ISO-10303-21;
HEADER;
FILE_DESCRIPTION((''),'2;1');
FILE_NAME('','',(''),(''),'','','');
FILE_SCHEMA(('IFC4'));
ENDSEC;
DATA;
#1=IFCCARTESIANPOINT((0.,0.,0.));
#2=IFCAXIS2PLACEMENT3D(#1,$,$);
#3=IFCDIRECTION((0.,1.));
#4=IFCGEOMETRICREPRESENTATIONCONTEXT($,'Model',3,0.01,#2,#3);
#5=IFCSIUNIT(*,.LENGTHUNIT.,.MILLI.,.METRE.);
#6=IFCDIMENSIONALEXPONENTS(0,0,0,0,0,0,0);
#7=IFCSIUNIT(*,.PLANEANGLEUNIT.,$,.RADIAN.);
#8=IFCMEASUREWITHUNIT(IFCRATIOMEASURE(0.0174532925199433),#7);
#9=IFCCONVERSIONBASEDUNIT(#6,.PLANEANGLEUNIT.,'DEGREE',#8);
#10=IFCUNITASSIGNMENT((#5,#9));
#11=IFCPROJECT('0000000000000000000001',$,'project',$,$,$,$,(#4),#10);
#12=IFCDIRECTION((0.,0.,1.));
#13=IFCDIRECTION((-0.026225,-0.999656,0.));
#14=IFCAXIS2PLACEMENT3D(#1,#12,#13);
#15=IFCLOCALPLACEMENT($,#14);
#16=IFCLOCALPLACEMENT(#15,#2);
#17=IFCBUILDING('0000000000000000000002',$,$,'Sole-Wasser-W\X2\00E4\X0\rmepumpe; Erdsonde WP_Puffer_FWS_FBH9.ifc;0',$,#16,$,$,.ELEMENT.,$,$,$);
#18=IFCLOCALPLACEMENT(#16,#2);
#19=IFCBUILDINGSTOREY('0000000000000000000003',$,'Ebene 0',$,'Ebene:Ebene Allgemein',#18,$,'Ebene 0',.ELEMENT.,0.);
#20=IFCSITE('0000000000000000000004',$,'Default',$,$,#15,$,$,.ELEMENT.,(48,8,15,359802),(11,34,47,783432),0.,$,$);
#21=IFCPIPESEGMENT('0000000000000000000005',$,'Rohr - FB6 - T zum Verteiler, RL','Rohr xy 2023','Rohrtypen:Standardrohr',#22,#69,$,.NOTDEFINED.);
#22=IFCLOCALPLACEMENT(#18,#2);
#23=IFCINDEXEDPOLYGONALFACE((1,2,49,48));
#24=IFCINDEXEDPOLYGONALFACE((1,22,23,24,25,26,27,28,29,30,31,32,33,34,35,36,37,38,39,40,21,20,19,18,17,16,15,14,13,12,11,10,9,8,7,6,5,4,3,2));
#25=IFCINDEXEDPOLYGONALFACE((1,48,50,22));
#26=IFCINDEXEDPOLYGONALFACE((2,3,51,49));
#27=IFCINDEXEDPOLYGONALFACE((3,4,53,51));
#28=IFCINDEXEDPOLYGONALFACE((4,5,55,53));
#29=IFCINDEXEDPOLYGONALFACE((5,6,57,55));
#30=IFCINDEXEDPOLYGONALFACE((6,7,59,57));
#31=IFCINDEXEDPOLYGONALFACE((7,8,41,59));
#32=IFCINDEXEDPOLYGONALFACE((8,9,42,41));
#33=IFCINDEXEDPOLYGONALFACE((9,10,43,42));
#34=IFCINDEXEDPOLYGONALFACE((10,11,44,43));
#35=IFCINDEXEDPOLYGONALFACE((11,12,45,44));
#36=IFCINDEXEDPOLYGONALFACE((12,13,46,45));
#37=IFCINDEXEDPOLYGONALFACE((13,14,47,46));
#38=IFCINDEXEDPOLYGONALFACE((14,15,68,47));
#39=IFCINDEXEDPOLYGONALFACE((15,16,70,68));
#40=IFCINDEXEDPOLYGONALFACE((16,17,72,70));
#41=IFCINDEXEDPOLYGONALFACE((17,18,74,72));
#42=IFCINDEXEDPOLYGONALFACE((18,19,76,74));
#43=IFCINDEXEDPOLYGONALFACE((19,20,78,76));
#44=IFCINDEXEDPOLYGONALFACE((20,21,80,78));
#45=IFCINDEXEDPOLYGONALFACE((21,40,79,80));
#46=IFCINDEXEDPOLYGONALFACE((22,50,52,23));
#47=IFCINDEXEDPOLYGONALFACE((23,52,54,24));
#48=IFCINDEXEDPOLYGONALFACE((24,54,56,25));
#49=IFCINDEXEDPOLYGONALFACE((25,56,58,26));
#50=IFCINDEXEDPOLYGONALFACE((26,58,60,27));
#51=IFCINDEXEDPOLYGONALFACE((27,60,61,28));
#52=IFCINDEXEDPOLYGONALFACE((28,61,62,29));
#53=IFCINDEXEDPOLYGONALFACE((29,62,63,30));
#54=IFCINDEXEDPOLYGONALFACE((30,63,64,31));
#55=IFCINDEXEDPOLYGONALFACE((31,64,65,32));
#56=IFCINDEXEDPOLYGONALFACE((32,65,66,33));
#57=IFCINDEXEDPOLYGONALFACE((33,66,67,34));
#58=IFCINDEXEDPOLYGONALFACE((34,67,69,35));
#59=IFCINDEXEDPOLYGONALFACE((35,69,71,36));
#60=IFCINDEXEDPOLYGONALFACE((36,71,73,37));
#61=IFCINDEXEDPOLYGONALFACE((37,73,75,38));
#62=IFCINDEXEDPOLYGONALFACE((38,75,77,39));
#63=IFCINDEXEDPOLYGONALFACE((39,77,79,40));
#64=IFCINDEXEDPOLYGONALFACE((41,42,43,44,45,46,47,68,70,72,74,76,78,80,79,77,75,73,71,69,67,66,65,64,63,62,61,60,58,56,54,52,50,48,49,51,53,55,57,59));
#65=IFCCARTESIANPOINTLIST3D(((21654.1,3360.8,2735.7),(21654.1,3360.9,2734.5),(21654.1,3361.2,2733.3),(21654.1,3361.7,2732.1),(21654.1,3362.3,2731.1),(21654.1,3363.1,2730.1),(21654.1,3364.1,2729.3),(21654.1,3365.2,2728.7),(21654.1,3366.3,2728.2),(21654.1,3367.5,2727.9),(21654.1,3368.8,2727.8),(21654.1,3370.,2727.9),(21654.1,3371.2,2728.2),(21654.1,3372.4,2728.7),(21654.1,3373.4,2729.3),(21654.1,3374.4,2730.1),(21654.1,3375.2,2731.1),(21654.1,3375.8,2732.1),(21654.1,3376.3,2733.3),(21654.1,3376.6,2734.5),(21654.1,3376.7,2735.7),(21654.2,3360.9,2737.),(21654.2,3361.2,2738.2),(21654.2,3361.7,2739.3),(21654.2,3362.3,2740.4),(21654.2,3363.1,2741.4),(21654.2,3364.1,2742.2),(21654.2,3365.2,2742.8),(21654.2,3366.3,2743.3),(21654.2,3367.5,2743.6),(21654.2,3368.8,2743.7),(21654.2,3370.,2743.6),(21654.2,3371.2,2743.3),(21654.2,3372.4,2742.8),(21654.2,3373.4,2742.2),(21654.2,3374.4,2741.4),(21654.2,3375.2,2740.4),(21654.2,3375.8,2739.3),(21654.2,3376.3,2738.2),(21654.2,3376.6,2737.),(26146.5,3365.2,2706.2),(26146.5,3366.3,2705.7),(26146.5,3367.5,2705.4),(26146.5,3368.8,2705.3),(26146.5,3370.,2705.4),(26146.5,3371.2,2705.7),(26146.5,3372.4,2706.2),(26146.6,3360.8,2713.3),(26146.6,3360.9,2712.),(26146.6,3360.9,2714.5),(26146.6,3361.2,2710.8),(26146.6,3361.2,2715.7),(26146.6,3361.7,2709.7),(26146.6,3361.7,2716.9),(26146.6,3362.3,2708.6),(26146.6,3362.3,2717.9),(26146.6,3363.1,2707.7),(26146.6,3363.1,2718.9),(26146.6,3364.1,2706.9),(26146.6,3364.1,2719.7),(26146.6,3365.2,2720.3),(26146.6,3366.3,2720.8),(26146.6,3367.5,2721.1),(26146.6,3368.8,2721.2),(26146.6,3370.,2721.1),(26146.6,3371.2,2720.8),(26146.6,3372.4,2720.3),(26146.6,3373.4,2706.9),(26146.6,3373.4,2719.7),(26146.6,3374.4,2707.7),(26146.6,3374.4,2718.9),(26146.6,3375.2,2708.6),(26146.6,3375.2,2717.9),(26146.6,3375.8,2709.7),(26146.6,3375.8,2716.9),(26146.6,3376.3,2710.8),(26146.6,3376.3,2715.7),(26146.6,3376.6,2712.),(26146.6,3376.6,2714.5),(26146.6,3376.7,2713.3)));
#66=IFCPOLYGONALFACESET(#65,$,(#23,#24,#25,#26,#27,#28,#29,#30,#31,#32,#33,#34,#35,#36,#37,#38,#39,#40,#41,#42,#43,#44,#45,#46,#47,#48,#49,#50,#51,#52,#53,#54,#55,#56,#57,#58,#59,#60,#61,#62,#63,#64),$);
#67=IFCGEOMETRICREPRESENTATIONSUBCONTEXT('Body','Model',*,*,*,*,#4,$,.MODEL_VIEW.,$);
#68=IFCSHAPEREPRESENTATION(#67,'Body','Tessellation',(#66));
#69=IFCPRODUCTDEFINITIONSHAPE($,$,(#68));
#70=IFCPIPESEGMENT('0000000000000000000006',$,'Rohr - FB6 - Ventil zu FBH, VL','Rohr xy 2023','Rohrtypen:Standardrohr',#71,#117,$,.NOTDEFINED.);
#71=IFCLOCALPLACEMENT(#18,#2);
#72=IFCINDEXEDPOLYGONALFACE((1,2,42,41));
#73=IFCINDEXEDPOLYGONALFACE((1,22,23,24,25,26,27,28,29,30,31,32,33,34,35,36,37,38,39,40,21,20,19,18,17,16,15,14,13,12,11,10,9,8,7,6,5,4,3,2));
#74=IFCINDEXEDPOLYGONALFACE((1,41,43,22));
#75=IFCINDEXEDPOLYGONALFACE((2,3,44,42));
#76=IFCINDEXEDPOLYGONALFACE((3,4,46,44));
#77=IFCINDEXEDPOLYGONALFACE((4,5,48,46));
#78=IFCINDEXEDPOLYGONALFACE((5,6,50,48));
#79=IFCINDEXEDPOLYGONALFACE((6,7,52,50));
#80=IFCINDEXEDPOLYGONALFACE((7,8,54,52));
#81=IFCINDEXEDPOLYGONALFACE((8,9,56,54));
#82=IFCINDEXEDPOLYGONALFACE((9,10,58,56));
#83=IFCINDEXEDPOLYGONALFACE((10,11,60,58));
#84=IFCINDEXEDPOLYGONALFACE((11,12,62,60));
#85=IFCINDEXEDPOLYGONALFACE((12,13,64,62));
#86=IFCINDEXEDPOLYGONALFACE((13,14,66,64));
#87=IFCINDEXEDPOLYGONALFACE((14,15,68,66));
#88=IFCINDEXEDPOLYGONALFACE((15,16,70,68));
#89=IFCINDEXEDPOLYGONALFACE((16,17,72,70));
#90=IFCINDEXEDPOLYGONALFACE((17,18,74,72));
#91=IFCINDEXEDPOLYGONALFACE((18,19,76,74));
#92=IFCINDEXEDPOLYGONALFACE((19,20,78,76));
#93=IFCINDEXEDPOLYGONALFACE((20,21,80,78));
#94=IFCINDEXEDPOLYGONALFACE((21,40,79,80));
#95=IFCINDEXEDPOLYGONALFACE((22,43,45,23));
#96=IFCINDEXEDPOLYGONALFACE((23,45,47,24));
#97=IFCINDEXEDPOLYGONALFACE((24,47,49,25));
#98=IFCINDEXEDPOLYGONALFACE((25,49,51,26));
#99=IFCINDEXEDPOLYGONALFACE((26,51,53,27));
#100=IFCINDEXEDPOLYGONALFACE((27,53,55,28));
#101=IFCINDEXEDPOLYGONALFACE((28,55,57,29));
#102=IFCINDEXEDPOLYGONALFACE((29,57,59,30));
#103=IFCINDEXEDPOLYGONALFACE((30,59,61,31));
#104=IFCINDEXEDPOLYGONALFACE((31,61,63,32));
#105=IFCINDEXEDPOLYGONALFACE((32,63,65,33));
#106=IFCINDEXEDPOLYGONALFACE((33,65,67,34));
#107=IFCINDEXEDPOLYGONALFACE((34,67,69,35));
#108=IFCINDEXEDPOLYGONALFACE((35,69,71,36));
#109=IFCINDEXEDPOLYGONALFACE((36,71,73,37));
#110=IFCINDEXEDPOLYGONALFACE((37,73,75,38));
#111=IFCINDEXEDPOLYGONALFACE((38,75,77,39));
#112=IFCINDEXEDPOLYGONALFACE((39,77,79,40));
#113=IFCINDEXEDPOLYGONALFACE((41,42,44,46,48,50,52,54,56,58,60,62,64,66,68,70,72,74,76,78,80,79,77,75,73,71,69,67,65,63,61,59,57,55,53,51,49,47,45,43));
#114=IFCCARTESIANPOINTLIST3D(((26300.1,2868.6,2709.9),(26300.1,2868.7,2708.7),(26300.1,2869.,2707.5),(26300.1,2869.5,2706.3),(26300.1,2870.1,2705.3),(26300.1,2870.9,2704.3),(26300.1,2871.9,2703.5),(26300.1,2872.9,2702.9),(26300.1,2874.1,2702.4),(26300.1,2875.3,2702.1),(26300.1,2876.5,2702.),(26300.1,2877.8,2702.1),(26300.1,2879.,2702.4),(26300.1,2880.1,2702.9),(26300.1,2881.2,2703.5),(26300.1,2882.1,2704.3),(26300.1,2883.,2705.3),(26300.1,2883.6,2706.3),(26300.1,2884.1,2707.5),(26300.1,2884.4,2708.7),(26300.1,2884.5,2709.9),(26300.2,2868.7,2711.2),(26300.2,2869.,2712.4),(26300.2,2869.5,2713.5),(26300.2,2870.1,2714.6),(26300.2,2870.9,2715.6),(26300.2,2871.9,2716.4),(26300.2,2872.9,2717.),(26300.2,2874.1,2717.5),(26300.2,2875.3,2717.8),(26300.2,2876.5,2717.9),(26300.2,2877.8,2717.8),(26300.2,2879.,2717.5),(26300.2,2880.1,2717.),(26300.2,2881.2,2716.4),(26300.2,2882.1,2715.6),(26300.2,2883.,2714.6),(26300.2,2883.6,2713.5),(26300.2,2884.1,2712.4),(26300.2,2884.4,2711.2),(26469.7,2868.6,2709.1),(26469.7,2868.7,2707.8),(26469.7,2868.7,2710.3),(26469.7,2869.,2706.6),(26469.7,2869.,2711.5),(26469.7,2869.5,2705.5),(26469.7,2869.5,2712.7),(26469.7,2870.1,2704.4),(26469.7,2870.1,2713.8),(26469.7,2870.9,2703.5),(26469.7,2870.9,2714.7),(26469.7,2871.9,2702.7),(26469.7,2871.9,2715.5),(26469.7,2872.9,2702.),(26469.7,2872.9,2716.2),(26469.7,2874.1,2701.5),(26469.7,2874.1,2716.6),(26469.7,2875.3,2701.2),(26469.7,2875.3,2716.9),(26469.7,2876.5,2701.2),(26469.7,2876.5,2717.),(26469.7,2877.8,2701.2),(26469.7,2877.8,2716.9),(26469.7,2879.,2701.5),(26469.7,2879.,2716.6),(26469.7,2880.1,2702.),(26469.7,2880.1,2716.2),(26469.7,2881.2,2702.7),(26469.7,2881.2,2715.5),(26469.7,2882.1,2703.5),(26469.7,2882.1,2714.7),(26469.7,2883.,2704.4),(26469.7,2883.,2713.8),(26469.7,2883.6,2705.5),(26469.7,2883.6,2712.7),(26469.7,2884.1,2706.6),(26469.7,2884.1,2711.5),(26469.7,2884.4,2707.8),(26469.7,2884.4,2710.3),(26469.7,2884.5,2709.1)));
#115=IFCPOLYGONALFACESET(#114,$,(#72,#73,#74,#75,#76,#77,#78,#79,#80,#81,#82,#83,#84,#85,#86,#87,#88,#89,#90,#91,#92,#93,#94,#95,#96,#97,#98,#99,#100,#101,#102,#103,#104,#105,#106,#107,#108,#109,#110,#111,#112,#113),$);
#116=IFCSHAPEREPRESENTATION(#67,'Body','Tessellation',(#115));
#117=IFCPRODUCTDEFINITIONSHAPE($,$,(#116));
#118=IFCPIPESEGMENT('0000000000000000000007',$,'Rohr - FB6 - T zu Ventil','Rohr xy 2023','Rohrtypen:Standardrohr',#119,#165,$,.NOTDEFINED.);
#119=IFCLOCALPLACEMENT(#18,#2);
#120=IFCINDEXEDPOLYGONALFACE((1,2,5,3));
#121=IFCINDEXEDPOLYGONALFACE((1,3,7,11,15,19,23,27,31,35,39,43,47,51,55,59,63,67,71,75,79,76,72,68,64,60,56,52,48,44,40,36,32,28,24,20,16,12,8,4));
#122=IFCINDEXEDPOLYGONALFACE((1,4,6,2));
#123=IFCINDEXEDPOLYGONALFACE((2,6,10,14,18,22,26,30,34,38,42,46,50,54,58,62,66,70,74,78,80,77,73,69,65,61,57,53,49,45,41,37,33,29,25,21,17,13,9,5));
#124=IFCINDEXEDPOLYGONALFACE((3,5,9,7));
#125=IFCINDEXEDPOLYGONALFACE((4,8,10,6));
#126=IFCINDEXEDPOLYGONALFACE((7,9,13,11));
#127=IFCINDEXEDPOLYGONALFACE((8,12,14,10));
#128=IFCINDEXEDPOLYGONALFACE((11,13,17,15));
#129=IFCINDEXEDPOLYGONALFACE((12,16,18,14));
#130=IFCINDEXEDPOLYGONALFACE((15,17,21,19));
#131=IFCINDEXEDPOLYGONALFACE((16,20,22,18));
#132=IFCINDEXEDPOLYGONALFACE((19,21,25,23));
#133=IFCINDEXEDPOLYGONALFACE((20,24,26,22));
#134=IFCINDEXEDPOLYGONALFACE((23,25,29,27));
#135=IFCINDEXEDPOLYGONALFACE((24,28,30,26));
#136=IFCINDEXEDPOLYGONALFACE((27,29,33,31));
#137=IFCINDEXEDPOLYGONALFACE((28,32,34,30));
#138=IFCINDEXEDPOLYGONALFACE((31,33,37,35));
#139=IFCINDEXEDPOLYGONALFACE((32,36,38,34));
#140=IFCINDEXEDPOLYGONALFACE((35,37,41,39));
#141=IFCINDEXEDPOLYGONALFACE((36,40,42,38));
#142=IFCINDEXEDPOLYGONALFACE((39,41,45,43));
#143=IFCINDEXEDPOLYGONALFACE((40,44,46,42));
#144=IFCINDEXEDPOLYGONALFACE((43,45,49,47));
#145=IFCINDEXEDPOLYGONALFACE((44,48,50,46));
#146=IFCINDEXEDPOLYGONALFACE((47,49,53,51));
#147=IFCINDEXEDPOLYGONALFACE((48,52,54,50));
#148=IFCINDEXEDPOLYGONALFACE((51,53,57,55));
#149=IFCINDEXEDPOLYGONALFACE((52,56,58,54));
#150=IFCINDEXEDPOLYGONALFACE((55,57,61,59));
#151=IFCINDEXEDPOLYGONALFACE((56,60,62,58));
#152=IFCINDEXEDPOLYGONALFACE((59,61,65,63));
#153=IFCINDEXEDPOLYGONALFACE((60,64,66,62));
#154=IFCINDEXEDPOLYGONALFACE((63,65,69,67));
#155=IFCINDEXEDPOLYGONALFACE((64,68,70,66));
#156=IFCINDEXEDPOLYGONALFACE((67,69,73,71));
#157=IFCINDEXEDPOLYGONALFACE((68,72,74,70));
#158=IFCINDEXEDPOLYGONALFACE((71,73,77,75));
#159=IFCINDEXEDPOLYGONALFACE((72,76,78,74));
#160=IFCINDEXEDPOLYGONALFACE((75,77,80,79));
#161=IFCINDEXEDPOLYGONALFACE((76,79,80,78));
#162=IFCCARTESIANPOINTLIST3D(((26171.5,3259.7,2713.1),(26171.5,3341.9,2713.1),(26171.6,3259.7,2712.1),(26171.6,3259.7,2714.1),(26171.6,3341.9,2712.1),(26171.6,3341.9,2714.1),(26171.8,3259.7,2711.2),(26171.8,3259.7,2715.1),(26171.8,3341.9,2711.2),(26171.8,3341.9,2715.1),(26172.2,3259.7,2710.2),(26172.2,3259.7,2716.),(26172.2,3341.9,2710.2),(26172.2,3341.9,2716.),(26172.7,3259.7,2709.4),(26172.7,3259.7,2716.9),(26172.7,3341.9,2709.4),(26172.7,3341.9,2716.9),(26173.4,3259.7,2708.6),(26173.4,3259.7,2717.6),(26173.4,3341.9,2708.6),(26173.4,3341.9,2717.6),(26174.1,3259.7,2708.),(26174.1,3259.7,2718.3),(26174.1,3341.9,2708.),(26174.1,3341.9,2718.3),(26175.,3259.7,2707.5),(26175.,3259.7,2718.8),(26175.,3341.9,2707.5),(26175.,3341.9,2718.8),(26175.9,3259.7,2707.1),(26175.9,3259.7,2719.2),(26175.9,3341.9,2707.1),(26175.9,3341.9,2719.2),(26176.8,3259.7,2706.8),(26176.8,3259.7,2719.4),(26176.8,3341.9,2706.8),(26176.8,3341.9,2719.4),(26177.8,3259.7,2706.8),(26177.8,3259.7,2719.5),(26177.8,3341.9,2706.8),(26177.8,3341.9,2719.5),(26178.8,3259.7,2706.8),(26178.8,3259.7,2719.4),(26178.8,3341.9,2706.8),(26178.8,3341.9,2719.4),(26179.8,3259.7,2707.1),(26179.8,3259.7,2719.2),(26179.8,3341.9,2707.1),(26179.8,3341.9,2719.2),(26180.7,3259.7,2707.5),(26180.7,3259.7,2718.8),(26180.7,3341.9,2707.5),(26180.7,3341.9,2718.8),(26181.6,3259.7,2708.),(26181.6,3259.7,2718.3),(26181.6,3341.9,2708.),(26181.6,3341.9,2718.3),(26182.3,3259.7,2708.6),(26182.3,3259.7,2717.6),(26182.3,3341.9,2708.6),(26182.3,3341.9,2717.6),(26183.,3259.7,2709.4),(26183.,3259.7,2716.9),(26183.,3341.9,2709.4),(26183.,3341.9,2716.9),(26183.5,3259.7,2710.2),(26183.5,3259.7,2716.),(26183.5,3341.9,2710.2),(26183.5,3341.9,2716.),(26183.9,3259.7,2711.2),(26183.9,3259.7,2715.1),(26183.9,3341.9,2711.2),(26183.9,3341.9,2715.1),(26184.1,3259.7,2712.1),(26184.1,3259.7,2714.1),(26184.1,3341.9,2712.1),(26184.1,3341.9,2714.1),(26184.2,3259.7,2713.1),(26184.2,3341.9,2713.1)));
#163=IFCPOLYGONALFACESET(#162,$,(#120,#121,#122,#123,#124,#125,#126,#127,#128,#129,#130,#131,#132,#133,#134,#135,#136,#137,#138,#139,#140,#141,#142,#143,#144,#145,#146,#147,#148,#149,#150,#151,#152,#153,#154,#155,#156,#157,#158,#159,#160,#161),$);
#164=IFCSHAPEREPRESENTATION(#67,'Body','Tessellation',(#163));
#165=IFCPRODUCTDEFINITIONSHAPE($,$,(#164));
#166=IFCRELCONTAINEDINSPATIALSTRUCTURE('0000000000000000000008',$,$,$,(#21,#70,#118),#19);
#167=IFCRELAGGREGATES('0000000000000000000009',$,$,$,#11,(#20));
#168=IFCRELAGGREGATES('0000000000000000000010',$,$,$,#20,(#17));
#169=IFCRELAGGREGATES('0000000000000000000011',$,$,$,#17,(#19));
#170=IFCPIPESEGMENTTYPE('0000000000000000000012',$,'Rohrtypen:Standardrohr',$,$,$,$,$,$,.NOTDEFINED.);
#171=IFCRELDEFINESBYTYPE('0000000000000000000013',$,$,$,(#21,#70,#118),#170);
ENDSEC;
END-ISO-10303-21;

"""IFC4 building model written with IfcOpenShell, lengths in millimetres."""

from ifc_helpers import new_model, entity, si_unit, converted_unit, direction, frame, origin, place, context, subcontext, project, spatial, indexed_curve, outline, extrude, type_object, element, save


model = new_model("IFC4")

# Units and contexts
model_context = context("Model", 3, precision=0.01, world=origin(), true_north=direction((0.0, 1.0)))
body_context = subcontext(model_context, "Body", "Model", "MODEL_VIEW")
ifc_project = project(units=[si_unit("LENGTHUNIT", "METRE", prefix="MILLI"), converted_unit("PLANEANGLEUNIT", "DEGREE", entity("IfcRatioMeasure", 0.0174532925199433), si_unit("PLANEANGLEUNIT", "RADIAN"), dimensions=[0, 0, 0, 0, 0, 0, 0])], contexts=[model_context])

# Site, building, storey
site_placement = place(None, frame((0.0, 0.0, 0.0), z_axis=(0.0, 0.0, 1.0), x_axis=(-0.026225, -0.999656, 0.0)))
site = spatial("IfcSite", under=ifc_project, at=site_placement, Name="Default", CompositionType="ELEMENT", RefLatitude=(48, 8, 15, 359802), RefLongitude=(11, 34, 47, 783432), RefElevation=0.0)
building_placement = place(site_placement, origin())
building = spatial("IfcBuilding", under=site, at=building_placement, Description="Sole-Wasser-Wärmepumpe; Erdsonde WP_Puffer_FWS_FBH9.ifc;0", CompositionType="ELEMENT")
storey_placement = place(building_placement, origin())
storey = spatial("IfcBuildingStorey", under=building, at=storey_placement, Name="Ebene 0", ObjectType="Ebene:Ebene Allgemein", LongName="Ebene 0", CompositionType="ELEMENT", Elevation=0.0)

# Pipe segments
pipe_segment_type = type_object("IfcPipeSegmentType", Name="Rohrtypen:Standardrohr", PredefinedType="NOTDEFINED")
pipe_segment_1_placement = place(storey_placement, origin())
element("IfcPipeSegment", 1, at=pipe_segment_1_placement, inside=storey, type_object=pipe_segment_type, Name="Rohr - FB6 - T zum Verteiler, RL", Description="Rohr xy 2023", ObjectType="Rohrtypen:Standardrohr", PredefinedType="NOTDEFINED", context=body_context, shape_type="SweptSolid", body=[
    extrude(outline(indexed_curve([(7.9, 0.0), (7.8, 1.2), (7.6, 2.5), (7.1, 3.6), (6.4, 4.7), (5.6, 5.6), (4.7, 6.4), (3.6, 7.1), (2.5, 7.6), (1.2, 7.8), (0.0, 7.9), (-1.2, 7.8), (-2.5, 7.6), (-3.6, 7.1), (-4.7, 6.4), (-5.6, 5.6), (-6.4, 4.7), (-7.1, 3.6), (-7.6, 2.5), (-7.8, 1.2), (-7.9, 0.0), (-7.8, -1.2), (-7.6, -2.5), (-7.1, -3.6), (-6.4, -4.7), (-5.6, -5.6), (-4.7, -6.4), (-3.6, -7.1), (-2.5, -7.6), (-1.2, -7.8), (0.0, -7.9), (1.2, -7.8), (2.5, -7.6), (3.6, -7.1), (4.7, -6.4), (5.6, -5.6), (6.4, -4.7), (7.1, -3.6), (7.6, -2.5), (7.8, -1.2), (7.9, 0.0)], self_intersect=False)), frame((26146.6, 3368.8, 2713.3), z_axis=(-0.999988, 0.0, 0.005), x_axis=(0.0, 1.0, 0.0)), (0.0, 0.0, 1.0), 4492.5),
])
pipe_segment_2_placement = place(storey_placement, origin())
element("IfcPipeSegment", 2, at=pipe_segment_2_placement, inside=storey, type_object=pipe_segment_type, Name="Rohr - FB6 - Ventil zu FBH, VL", Description="Rohr xy 2023", ObjectType="Rohrtypen:Standardrohr", PredefinedType="NOTDEFINED", context=body_context, shape_type="SweptSolid", body=[
    extrude(outline(indexed_curve([(7.9, 0.0), (7.8, 1.2), (7.6, 2.5), (7.1, 3.6), (6.4, 4.7), (5.6, 5.6), (4.7, 6.4), (3.6, 7.1), (2.5, 7.6), (1.2, 7.8), (0.0, 7.9), (-1.2, 7.8), (-2.5, 7.6), (-3.6, 7.1), (-4.7, 6.4), (-5.6, 5.6), (-6.4, 4.7), (-7.1, 3.6), (-7.6, 2.5), (-7.8, 1.2), (-7.9, 0.0), (-7.8, -1.2), (-7.6, -2.5), (-7.1, -3.6), (-6.4, -4.7), (-5.6, -5.6), (-4.7, -6.4), (-3.6, -7.1), (-2.5, -7.6), (-1.2, -7.8), (0.0, -7.9), (1.2, -7.8), (2.5, -7.6), (3.6, -7.1), (4.7, -6.4), (5.6, -5.6), (6.4, -4.7), (7.1, -3.6), (7.6, -2.5), (7.8, -1.2), (7.9, 0.0)], self_intersect=False)), frame((26300.1, 2876.5, 2709.9), z_axis=(0.999988, 0.0, -0.005), x_axis=(0.0, 1.0, 0.0)), (0.0, 0.0, 1.0), 169.5),
])
pipe_segment_3_placement = place(storey_placement, origin())
element("IfcPipeSegment", 3, at=pipe_segment_3_placement, inside=storey, type_object=pipe_segment_type, Name="Rohr - FB6 - T zu Ventil", Description="Rohr xy 2023", ObjectType="Rohrtypen:Standardrohr", PredefinedType="NOTDEFINED", context=body_context, shape_type="SweptSolid", body=[
    extrude(outline(indexed_curve([(6.3, 0.0), (6.3, 1.0), (6.0, 2.0), (5.7, 2.9), (5.1, 3.7), (4.5, 4.5), (3.7, 5.1), (2.9, 5.7), (2.0, 6.0), (1.0, 6.3), (0.0, 6.4), (-1.0, 6.3), (-2.0, 6.0), (-2.9, 5.7), (-3.7, 5.1), (-4.5, 4.5), (-5.1, 3.7), (-5.7, 2.9), (-6.0, 2.0), (-6.3, 1.0), (-6.3, 0.0), (-6.3, -1.0), (-6.0, -2.0), (-5.7, -2.9), (-5.1, -3.7), (-4.5, -4.5), (-3.7, -5.1), (-2.9, -5.7), (-2.0, -6.0), (-1.0, -6.3), (0.0, -6.4), (1.0, -6.3), (2.0, -6.0), (2.9, -5.7), (3.7, -5.1), (4.5, -4.5), (5.1, -3.7), (5.7, -2.9), (6.0, -2.0), (6.3, -1.0), (6.3, 0.0)], self_intersect=False)), frame((26177.8, 3259.7, 2713.1), z_axis=(0.0, 1.0, 0.0), x_axis=(-1.0, 0.0, 0.0)), (0.0, 0.0, 1.0), 82.2),
])

save(model, "model.ifc")
